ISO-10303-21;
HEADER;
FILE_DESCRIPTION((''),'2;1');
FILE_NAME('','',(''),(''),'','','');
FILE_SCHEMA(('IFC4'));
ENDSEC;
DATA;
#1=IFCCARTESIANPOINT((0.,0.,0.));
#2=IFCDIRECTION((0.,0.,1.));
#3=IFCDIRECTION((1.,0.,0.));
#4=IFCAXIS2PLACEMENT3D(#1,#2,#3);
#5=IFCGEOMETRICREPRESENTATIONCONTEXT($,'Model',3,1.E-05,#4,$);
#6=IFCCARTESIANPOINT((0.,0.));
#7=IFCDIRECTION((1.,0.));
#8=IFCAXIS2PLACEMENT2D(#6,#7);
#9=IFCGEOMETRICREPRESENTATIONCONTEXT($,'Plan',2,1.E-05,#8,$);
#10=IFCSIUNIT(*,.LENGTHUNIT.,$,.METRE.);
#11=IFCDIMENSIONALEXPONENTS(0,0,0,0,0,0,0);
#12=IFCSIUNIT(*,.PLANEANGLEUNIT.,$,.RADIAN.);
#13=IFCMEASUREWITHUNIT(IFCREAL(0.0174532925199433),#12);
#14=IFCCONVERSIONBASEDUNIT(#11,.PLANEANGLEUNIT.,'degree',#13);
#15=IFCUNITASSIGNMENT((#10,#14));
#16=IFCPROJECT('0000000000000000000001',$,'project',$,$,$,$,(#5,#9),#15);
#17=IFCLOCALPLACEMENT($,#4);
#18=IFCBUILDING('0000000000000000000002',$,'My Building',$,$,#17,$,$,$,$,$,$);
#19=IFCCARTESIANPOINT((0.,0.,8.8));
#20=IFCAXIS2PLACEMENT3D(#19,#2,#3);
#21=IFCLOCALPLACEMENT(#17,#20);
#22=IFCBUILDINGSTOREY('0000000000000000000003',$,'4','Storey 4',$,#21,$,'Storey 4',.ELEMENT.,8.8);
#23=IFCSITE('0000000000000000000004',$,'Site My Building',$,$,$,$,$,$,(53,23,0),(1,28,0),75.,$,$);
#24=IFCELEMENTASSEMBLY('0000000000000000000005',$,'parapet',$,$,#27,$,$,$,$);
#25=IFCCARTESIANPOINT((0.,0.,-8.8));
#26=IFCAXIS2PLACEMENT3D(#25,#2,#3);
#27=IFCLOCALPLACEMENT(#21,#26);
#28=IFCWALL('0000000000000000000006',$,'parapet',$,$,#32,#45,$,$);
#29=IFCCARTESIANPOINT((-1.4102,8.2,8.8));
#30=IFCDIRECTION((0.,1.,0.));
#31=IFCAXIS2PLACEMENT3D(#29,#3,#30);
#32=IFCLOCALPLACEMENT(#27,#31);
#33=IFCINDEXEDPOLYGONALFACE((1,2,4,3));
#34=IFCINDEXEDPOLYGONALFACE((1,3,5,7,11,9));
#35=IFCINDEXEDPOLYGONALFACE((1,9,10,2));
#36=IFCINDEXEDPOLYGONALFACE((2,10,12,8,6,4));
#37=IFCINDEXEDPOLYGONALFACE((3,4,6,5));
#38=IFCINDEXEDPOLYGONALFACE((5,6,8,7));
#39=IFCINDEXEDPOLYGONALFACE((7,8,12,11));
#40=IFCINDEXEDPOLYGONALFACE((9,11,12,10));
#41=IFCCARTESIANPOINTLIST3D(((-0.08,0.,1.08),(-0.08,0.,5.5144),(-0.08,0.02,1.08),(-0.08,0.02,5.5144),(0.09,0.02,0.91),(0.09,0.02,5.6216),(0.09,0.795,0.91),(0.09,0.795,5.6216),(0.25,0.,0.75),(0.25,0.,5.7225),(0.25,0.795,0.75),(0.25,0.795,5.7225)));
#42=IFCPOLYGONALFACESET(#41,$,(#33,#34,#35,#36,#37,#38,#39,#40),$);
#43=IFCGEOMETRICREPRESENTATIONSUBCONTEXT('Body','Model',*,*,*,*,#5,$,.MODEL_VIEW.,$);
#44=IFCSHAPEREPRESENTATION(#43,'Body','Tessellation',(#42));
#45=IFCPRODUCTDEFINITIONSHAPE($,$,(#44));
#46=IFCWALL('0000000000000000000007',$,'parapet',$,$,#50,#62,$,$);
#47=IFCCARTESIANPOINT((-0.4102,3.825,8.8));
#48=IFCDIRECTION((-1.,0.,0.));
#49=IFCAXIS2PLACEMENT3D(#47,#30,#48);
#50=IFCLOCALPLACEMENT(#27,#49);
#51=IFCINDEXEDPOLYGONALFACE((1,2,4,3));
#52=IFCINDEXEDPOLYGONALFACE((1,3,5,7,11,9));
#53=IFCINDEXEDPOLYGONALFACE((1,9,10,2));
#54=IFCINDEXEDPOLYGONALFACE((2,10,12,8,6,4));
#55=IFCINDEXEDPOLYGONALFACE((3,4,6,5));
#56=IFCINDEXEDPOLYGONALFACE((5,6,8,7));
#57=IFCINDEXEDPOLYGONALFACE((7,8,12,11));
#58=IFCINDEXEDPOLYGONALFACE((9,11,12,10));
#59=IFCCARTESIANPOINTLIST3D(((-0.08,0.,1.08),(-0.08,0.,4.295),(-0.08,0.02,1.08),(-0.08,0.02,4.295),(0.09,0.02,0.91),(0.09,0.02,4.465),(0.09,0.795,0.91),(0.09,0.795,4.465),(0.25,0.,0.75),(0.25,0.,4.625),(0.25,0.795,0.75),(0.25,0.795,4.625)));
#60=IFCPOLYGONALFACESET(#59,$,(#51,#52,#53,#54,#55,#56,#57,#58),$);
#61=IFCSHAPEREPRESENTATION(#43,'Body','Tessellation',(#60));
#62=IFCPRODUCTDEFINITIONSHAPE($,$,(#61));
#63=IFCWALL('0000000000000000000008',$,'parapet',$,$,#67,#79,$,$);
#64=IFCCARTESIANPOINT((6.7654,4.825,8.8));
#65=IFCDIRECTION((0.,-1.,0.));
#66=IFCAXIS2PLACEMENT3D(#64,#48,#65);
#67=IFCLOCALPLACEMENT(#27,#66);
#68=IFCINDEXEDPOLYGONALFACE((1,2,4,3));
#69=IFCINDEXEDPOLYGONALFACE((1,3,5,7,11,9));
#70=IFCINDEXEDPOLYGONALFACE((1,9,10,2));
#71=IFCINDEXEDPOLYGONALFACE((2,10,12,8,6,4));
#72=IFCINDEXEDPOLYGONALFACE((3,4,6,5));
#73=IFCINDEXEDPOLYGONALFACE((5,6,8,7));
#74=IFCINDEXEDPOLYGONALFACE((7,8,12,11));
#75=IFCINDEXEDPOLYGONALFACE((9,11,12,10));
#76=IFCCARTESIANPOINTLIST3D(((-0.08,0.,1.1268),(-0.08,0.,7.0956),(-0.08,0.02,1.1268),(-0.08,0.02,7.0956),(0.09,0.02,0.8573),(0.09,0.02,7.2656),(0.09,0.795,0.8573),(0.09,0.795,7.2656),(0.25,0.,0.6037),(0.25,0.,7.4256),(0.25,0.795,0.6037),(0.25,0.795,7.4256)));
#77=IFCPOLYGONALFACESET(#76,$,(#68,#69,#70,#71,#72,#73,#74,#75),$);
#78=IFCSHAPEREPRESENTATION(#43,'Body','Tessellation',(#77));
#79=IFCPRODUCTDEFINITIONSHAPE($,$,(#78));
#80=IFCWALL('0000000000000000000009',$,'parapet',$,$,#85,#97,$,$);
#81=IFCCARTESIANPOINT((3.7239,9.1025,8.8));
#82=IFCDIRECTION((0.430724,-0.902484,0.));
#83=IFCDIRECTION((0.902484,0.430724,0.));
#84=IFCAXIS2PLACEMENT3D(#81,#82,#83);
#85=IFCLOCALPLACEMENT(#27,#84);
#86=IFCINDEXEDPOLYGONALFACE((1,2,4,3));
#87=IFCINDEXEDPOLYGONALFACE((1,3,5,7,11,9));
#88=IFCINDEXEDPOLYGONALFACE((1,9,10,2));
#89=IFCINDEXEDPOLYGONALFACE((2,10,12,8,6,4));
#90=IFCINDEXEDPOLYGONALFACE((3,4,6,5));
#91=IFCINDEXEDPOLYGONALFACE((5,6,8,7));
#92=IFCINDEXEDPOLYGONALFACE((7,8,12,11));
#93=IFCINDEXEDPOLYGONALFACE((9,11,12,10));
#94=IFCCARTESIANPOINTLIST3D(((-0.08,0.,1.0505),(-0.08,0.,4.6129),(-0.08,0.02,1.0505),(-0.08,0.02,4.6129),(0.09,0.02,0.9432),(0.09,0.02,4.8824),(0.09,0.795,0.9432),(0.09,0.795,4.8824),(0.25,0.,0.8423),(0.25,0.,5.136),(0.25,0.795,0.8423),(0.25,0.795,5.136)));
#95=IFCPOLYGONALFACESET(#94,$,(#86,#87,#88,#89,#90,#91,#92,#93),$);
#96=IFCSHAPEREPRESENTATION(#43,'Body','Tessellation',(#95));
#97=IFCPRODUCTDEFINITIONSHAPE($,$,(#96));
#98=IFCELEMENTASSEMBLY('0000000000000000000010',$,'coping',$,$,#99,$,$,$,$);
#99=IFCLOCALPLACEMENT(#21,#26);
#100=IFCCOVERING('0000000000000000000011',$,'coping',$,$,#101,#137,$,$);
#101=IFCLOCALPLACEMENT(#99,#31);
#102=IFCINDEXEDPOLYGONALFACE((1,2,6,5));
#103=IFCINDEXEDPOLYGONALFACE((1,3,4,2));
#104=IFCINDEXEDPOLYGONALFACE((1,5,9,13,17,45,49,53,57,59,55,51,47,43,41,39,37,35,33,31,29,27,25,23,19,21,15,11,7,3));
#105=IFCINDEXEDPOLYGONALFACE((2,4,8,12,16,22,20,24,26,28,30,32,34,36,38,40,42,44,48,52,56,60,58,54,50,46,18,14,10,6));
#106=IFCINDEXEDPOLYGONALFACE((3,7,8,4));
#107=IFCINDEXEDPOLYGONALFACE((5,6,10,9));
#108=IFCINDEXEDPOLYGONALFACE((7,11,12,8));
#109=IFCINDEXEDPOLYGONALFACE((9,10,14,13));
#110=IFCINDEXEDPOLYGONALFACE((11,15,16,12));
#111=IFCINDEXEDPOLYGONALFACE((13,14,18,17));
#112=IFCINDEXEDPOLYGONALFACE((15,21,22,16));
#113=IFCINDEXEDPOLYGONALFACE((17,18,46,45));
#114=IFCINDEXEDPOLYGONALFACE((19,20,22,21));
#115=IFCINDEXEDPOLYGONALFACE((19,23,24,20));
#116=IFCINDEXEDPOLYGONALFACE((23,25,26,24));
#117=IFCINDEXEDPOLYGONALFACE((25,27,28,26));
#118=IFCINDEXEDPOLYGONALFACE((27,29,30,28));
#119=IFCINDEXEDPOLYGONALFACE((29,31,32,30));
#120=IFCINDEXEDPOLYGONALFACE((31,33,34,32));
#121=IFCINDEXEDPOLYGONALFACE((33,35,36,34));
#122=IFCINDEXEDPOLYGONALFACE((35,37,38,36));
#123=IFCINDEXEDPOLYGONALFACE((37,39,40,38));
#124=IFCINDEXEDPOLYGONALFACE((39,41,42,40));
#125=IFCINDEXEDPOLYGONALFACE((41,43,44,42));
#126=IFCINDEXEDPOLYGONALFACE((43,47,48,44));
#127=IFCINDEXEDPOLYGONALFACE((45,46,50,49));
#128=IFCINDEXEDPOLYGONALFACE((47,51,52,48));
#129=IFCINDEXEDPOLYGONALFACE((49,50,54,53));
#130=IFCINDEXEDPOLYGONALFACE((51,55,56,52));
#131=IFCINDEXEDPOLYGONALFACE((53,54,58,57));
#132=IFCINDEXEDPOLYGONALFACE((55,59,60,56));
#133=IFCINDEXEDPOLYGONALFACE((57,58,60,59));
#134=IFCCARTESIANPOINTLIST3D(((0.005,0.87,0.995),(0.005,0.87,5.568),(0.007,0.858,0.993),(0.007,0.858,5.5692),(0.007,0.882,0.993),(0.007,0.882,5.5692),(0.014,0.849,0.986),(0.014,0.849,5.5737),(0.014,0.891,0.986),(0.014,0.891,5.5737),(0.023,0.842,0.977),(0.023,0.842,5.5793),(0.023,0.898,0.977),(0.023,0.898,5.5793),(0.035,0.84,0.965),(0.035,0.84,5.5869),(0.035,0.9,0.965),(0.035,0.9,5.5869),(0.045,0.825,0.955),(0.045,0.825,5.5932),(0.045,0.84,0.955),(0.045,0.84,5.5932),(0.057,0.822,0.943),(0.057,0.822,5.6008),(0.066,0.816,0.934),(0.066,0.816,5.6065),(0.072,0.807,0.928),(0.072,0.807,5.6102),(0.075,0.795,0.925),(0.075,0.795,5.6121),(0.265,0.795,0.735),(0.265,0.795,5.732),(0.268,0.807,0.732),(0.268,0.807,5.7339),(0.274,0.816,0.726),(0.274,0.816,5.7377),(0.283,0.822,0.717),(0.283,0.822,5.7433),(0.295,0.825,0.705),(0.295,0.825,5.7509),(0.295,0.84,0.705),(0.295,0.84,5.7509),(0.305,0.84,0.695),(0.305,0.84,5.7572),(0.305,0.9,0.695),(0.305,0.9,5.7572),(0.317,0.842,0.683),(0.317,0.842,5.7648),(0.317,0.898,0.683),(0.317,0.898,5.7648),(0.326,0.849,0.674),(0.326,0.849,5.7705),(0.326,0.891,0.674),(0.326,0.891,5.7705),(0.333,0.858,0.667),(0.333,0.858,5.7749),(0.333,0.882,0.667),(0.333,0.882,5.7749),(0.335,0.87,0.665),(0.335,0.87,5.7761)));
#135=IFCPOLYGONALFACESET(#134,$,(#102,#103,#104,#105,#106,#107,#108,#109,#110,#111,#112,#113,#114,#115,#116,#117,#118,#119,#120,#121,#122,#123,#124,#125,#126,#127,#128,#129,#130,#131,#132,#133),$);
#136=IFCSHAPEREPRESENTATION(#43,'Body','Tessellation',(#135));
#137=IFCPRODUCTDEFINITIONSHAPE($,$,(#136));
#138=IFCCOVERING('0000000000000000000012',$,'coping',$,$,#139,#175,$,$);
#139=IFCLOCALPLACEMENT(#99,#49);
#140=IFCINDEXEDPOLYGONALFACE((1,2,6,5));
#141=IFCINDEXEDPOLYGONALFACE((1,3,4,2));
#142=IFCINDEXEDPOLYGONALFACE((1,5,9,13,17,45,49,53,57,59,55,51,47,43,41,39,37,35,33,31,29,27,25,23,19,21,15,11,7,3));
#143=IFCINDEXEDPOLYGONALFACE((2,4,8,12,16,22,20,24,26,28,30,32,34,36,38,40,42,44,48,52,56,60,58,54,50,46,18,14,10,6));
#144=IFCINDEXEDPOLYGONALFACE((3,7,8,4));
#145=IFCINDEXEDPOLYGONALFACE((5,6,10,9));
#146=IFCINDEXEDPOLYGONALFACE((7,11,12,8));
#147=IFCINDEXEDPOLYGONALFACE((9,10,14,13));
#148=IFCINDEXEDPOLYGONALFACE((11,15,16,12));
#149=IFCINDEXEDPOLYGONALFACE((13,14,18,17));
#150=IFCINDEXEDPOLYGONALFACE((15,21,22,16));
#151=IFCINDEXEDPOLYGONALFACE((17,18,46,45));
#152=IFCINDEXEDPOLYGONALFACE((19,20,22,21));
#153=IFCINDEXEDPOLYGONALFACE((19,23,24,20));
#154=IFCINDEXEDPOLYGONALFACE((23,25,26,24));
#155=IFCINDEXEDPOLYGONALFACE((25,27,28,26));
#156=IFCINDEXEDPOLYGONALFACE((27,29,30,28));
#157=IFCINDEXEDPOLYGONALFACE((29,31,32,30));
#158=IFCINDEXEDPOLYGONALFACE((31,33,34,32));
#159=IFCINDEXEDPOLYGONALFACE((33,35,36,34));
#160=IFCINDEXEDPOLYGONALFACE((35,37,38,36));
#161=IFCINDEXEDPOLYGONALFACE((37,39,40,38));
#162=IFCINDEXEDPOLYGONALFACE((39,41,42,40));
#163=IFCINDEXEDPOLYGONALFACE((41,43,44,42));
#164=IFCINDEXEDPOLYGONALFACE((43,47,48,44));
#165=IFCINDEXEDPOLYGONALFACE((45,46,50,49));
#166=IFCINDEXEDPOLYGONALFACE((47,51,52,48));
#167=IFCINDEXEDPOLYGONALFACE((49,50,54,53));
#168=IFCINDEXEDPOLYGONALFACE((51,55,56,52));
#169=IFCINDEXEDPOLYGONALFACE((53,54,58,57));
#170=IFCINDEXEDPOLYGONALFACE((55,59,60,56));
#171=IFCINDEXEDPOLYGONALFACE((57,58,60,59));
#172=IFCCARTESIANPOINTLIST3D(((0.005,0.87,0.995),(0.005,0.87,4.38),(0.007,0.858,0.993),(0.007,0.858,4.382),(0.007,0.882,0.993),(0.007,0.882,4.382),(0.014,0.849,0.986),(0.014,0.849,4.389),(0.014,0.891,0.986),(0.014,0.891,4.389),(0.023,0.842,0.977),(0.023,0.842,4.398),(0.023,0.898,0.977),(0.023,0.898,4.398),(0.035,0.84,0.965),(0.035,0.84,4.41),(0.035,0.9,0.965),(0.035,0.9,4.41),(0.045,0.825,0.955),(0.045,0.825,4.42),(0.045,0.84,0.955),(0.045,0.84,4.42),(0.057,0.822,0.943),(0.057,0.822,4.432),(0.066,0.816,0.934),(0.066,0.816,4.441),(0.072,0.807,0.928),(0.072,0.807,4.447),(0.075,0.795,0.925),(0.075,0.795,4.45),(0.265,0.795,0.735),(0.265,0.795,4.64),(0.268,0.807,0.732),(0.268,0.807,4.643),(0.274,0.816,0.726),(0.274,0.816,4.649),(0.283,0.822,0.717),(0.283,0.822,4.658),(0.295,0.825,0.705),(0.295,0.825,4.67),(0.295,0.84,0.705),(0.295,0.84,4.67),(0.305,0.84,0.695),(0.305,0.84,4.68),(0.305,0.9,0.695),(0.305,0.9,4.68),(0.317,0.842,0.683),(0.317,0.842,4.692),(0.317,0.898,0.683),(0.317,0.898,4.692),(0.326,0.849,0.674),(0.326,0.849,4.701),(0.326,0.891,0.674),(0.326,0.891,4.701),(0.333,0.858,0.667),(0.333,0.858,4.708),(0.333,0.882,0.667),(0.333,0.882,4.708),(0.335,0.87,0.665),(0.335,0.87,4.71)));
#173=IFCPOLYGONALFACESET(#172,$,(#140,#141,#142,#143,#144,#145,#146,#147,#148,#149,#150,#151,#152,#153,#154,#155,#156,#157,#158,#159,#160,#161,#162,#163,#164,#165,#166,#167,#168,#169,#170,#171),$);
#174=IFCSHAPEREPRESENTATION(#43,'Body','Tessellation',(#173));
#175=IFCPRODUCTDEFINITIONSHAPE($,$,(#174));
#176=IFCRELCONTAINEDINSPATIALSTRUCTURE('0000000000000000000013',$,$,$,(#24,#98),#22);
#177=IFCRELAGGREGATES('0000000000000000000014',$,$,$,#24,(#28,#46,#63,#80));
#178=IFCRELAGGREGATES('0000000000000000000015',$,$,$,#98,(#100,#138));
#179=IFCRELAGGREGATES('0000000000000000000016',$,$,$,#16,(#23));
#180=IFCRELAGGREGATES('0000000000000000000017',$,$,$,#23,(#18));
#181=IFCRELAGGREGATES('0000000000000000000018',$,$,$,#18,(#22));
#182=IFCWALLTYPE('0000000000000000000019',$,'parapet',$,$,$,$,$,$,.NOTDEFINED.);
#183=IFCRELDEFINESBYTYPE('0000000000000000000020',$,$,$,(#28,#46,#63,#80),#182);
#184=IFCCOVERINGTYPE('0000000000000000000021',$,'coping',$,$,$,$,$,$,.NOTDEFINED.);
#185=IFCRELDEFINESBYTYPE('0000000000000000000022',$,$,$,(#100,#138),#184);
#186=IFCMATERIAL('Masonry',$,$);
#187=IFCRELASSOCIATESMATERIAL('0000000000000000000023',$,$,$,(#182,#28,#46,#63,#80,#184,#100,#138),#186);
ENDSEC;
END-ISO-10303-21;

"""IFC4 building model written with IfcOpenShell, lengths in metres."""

from ifc_helpers import new_model, entity, si_unit, converted_unit, frame, origin_with_axes, origin_2d_with_axis, place, context, subcontext, project, spatial, polyline, outline, extrude, clip, halfspace, material, material_profile, profile_set, profile_usage, type_object, element, aggregate, save


model = new_model("IFC4")

# Units and contexts
model_context = context("Model", 3, precision=1e-05, world=origin_with_axes())
plan_context = context("Plan", 2, precision=1e-05, world=origin_2d_with_axis())
body_context = subcontext(model_context, "Body", "Model", "MODEL_VIEW")
ifc_project = project(units=[si_unit("LENGTHUNIT", "METRE"), converted_unit("PLANEANGLEUNIT", "degree", entity("IfcReal", 0.0174532925199433), si_unit("PLANEANGLEUNIT", "RADIAN"), dimensions=[0, 0, 0, 0, 0, 0, 0])], contexts=[model_context, plan_context])

# Site, building, storey
site = spatial("IfcSite", under=ifc_project, Name="Site My Building", RefLatitude=(53, 23, 0), RefLongitude=(1, 28, 0), RefElevation=75.0)
building_placement = place(None, origin_with_axes())
building = spatial("IfcBuilding", under=site, at=building_placement, Name="My Building")
storey_placement = place(building_placement, frame((0.0, 0.0, 8.8), z_axis=(0.0, 0.0, 1.0), x_axis=(1.0, 0.0, 0.0)))
storey = spatial("IfcBuildingStorey", under=building, at=storey_placement, Name="4", Description="Storey 4", LongName="Storey 4", CompositionType="ELEMENT", Elevation=8.8)

# Element assembly, walls
assembly_1_placement = place(storey_placement, frame((0.0, 0.0, -8.8), z_axis=(0.0, 0.0, 1.0), x_axis=(1.0, 0.0, 0.0)))
assembly_1 = element("IfcElementAssembly", 1, at=assembly_1_placement, inside=storey, Name="parapet")
ifc_material_1 = material(Name="Masonry")
ifc_material_profile_1 = material_profile(ifc_material_1, outline(polyline([(0.25, 0.0), (0.25, 0.795), (0.09, 0.795), (0.09, 0.02), (-0.08, 0.02), (-0.08, 0.0), (0.25, 0.0)])))
ifc_profile_set_1 = profile_set([ifc_material_profile_1])
ifc_profile_usage_1 = profile_usage(ifc_profile_set_1)
wall_type = type_object("IfcWallType", Name="parapet", PredefinedType="NOTDEFINED", material=ifc_profile_set_1)
wall_1_placement = place(assembly_1_placement, frame((-1.4102, 8.2, 8.8), z_axis=(1.0, 0.0, 0.0), x_axis=(0.0, 1.0, 0.0)))
wall_1 = element("IfcWall", 2, at=wall_1_placement, type_object=wall_type, material=ifc_profile_usage_1, Name="parapet", context=body_context, shape_type="Clipping", body=[
    clip(clip(extrude(outline(polyline([(0.25, 0.0), (0.25, 0.795), (0.09, 0.795), (0.09, 0.02), (-0.08, 0.02), (-0.08, 0.0), (0.25, 0.0)])), origin_with_axes(), (0.0, 0.0, 1.0), 6.5648), halfspace(frame((0.0, -8.8, 1.0), z_axis=(-0.707107, 0.0, -0.707107), x_axis=(0.0, 1.0, 0.0)), False)), halfspace(frame((0.0, -8.8, 5.5648), z_axis=(-0.533515, 0.0, 0.845791), x_axis=(0.0, 1.0, 0.0)), False)),
])
ifc_profile_usage_2 = profile_usage(ifc_profile_set_1)
wall_2_placement = place(assembly_1_placement, frame((-0.4102, 3.825, 8.8), z_axis=(0.0, 1.0, 0.0), x_axis=(-1.0, 0.0, 0.0)))
wall_2 = element("IfcWall", 3, at=wall_2_placement, type_object=wall_type, material=ifc_profile_usage_2, Name="parapet", context=body_context, shape_type="Clipping", body=[
    clip(clip(extrude(outline(polyline([(0.25, 0.0), (0.25, 0.795), (0.09, 0.795), (0.09, 0.02), (-0.08, 0.02), (-0.08, 0.0), (0.25, 0.0)])), origin_with_axes(), (0.0, 0.0, 1.0), 5.375), halfspace(frame((0.0, -8.8, 1.0), z_axis=(-0.707107, 0.0, -0.707107), x_axis=(0.0, 1.0, 0.0)), False)), halfspace(frame((0.0, -8.8, 4.375), z_axis=(-0.707107, 0.0, 0.707107), x_axis=(0.0, 1.0, 0.0)), False)),
])
ifc_profile_usage_3 = profile_usage(ifc_profile_set_1)
wall_3_placement = place(assembly_1_placement, frame((6.7654, 4.825, 8.8), z_axis=(-1.0, 0.0, 0.0), x_axis=(0.0, -1.0, 0.0)))
wall_3 = element("IfcWall", 4, at=wall_3_placement, type_object=wall_type, material=ifc_profile_usage_3, Name="parapet", context=body_context, shape_type="Clipping", body=[
    clip(clip(extrude(outline(polyline([(0.25, 0.0), (0.25, 0.795), (0.09, 0.795), (0.09, 0.02), (-0.08, 0.02), (-0.08, 0.0), (0.25, 0.0)])), origin_with_axes(), (0.0, 0.0, 1.0), 8.1756), halfspace(frame((0.0, -8.8, 1.0), z_axis=(-0.845791, 0.0, -0.533515), x_axis=(0.0, 1.0, 0.0)), False)), halfspace(frame((0.0, -8.8, 7.1756), z_axis=(-0.707107, 0.0, 0.707107), x_axis=(0.0, 1.0, 0.0)), False)),
])
ifc_profile_usage_4 = profile_usage(ifc_profile_set_1)
wall_4_placement = place(assembly_1_placement, frame((3.7239, 9.1025, 8.8), z_axis=(0.430724, -0.902484, 0.0), x_axis=(0.902484, 0.430724, 0.0)))
wall_4 = element("IfcWall", 5, at=wall_4_placement, type_object=wall_type, material=ifc_profile_usage_4, Name="parapet", context=body_context, shape_type="Clipping", body=[
    clip(clip(extrude(outline(polyline([(0.25, 0.0), (0.25, 0.795), (0.09, 0.795), (0.09, 0.02), (-0.08, 0.02), (-0.08, 0.0), (0.25, 0.0)])), origin_with_axes(), (0.0, 0.0, 1.0), 5.7397), halfspace(frame((0.0, -8.8, 1.0), z_axis=(-0.533515, 0.0, -0.845791), x_axis=(0.0, 1.0, 0.0)), False)), halfspace(frame((0.0, -8.8, 4.7397), z_axis=(-0.845791, 0.0, 0.533515), x_axis=(0.0, 1.0, 0.0)), False)),
])
aggregate(assembly_1, [wall_1, wall_2, wall_3, wall_4])

# Element assembly, coverings
assembly_2_placement = place(storey_placement, frame((0.0, 0.0, -8.8), z_axis=(0.0, 0.0, 1.0), x_axis=(1.0, 0.0, 0.0)))
assembly_2 = element("IfcElementAssembly", 6, at=assembly_2_placement, inside=storey, Name="coping")
ifc_material_profile_2 = material_profile(ifc_material_1, outline(polyline([(0.265, 0.795), (0.268, 0.807), (0.274, 0.816), (0.283, 0.822), (0.295, 0.825), (0.295, 0.84), (0.305, 0.84), (0.317, 0.842), (0.326, 0.849), (0.333, 0.858), (0.335, 0.87), (0.333, 0.882), (0.326, 0.891), (0.317, 0.898), (0.305, 0.9), (0.035, 0.9), (0.023, 0.898), (0.014, 0.891), (0.007, 0.882), (0.005, 0.87), (0.007, 0.858), (0.014, 0.849), (0.023, 0.842), (0.035, 0.84), (0.045, 0.84), (0.045, 0.825), (0.057, 0.822), (0.066, 0.816), (0.072, 0.807), (0.075, 0.795), (0.265, 0.795)])))
ifc_profile_set_2 = profile_set([ifc_material_profile_2])
ifc_profile_usage_5 = profile_usage(ifc_profile_set_2)
covering_type_1 = type_object("IfcCoveringType", Name="coping", PredefinedType="NOTDEFINED", material=ifc_profile_set_2)
covering_1_placement = place(assembly_2_placement, frame((-1.4102, 8.2, 8.8), z_axis=(1.0, 0.0, 0.0), x_axis=(0.0, 1.0, 0.0)))
covering_1 = element("IfcCovering", 7, at=covering_1_placement, type_object=covering_type_1, material=ifc_profile_usage_5, Name="coping", context=body_context, shape_type="Clipping", body=[
    clip(clip(extrude(outline(polyline([(0.265, 0.795), (0.268, 0.807), (0.274, 0.816), (0.283, 0.822), (0.295, 0.825), (0.295, 0.84), (0.305, 0.84), (0.317, 0.842), (0.326, 0.849), (0.333, 0.858), (0.335, 0.87), (0.333, 0.882), (0.326, 0.891), (0.317, 0.898), (0.305, 0.9), (0.035, 0.9), (0.023, 0.898), (0.014, 0.891), (0.007, 0.882), (0.005, 0.87), (0.007, 0.858), (0.014, 0.849), (0.023, 0.842), (0.035, 0.84), (0.045, 0.84), (0.045, 0.825), (0.057, 0.822), (0.066, 0.816), (0.072, 0.807), (0.075, 0.795), (0.265, 0.795)])), origin_with_axes(), (0.0, 0.0, 1.0), 6.5648), halfspace(frame((0.0, -8.8, 1.0), z_axis=(-0.707107, 0.0, -0.707107), x_axis=(0.0, 1.0, 0.0)), False)), halfspace(frame((0.0, -8.8, 5.5648), z_axis=(-0.533515, 0.0, 0.845791), x_axis=(0.0, 1.0, 0.0)), False)),
])
ifc_profile_usage_6 = profile_usage(ifc_profile_set_2)
covering_2_placement = place(assembly_2_placement, frame((-0.4102, 3.825, 8.8), z_axis=(0.0, 1.0, 0.0), x_axis=(-1.0, 0.0, 0.0)))
covering_2 = element("IfcCovering", 8, at=covering_2_placement, type_object=covering_type_1, material=ifc_profile_usage_6, Name="coping", context=body_context, shape_type="Clipping", body=[
    clip(clip(extrude(outline(polyline([(0.265, 0.795), (0.268, 0.807), (0.274, 0.816), (0.283, 0.822), (0.295, 0.825), (0.295, 0.84), (0.305, 0.84), (0.317, 0.842), (0.326, 0.849), (0.333, 0.858), (0.335, 0.87), (0.333, 0.882), (0.326, 0.891), (0.317, 0.898), (0.305, 0.9), (0.035, 0.9), (0.023, 0.898), (0.014, 0.891), (0.007, 0.882), (0.005, 0.87), (0.007, 0.858), (0.014, 0.849), (0.023, 0.842), (0.035, 0.84), (0.045, 0.84), (0.045, 0.825), (0.057, 0.822), (0.066, 0.816), (0.072, 0.807), (0.075, 0.795), (0.265, 0.795)])), origin_with_axes(), (0.0, 0.0, 1.0), 5.375), halfspace(frame((0.0, -8.8, 1.0), z_axis=(-0.707107, 0.0, -0.707107), x_axis=(0.0, 1.0, 0.0)), False)), halfspace(frame((0.0, -8.8, 4.375), z_axis=(-0.707107, 0.0, 0.707107), x_axis=(0.0, 1.0, 0.0)), False)),
])
aggregate(assembly_2, [covering_1, covering_2])

save(model, "model.ifc")
